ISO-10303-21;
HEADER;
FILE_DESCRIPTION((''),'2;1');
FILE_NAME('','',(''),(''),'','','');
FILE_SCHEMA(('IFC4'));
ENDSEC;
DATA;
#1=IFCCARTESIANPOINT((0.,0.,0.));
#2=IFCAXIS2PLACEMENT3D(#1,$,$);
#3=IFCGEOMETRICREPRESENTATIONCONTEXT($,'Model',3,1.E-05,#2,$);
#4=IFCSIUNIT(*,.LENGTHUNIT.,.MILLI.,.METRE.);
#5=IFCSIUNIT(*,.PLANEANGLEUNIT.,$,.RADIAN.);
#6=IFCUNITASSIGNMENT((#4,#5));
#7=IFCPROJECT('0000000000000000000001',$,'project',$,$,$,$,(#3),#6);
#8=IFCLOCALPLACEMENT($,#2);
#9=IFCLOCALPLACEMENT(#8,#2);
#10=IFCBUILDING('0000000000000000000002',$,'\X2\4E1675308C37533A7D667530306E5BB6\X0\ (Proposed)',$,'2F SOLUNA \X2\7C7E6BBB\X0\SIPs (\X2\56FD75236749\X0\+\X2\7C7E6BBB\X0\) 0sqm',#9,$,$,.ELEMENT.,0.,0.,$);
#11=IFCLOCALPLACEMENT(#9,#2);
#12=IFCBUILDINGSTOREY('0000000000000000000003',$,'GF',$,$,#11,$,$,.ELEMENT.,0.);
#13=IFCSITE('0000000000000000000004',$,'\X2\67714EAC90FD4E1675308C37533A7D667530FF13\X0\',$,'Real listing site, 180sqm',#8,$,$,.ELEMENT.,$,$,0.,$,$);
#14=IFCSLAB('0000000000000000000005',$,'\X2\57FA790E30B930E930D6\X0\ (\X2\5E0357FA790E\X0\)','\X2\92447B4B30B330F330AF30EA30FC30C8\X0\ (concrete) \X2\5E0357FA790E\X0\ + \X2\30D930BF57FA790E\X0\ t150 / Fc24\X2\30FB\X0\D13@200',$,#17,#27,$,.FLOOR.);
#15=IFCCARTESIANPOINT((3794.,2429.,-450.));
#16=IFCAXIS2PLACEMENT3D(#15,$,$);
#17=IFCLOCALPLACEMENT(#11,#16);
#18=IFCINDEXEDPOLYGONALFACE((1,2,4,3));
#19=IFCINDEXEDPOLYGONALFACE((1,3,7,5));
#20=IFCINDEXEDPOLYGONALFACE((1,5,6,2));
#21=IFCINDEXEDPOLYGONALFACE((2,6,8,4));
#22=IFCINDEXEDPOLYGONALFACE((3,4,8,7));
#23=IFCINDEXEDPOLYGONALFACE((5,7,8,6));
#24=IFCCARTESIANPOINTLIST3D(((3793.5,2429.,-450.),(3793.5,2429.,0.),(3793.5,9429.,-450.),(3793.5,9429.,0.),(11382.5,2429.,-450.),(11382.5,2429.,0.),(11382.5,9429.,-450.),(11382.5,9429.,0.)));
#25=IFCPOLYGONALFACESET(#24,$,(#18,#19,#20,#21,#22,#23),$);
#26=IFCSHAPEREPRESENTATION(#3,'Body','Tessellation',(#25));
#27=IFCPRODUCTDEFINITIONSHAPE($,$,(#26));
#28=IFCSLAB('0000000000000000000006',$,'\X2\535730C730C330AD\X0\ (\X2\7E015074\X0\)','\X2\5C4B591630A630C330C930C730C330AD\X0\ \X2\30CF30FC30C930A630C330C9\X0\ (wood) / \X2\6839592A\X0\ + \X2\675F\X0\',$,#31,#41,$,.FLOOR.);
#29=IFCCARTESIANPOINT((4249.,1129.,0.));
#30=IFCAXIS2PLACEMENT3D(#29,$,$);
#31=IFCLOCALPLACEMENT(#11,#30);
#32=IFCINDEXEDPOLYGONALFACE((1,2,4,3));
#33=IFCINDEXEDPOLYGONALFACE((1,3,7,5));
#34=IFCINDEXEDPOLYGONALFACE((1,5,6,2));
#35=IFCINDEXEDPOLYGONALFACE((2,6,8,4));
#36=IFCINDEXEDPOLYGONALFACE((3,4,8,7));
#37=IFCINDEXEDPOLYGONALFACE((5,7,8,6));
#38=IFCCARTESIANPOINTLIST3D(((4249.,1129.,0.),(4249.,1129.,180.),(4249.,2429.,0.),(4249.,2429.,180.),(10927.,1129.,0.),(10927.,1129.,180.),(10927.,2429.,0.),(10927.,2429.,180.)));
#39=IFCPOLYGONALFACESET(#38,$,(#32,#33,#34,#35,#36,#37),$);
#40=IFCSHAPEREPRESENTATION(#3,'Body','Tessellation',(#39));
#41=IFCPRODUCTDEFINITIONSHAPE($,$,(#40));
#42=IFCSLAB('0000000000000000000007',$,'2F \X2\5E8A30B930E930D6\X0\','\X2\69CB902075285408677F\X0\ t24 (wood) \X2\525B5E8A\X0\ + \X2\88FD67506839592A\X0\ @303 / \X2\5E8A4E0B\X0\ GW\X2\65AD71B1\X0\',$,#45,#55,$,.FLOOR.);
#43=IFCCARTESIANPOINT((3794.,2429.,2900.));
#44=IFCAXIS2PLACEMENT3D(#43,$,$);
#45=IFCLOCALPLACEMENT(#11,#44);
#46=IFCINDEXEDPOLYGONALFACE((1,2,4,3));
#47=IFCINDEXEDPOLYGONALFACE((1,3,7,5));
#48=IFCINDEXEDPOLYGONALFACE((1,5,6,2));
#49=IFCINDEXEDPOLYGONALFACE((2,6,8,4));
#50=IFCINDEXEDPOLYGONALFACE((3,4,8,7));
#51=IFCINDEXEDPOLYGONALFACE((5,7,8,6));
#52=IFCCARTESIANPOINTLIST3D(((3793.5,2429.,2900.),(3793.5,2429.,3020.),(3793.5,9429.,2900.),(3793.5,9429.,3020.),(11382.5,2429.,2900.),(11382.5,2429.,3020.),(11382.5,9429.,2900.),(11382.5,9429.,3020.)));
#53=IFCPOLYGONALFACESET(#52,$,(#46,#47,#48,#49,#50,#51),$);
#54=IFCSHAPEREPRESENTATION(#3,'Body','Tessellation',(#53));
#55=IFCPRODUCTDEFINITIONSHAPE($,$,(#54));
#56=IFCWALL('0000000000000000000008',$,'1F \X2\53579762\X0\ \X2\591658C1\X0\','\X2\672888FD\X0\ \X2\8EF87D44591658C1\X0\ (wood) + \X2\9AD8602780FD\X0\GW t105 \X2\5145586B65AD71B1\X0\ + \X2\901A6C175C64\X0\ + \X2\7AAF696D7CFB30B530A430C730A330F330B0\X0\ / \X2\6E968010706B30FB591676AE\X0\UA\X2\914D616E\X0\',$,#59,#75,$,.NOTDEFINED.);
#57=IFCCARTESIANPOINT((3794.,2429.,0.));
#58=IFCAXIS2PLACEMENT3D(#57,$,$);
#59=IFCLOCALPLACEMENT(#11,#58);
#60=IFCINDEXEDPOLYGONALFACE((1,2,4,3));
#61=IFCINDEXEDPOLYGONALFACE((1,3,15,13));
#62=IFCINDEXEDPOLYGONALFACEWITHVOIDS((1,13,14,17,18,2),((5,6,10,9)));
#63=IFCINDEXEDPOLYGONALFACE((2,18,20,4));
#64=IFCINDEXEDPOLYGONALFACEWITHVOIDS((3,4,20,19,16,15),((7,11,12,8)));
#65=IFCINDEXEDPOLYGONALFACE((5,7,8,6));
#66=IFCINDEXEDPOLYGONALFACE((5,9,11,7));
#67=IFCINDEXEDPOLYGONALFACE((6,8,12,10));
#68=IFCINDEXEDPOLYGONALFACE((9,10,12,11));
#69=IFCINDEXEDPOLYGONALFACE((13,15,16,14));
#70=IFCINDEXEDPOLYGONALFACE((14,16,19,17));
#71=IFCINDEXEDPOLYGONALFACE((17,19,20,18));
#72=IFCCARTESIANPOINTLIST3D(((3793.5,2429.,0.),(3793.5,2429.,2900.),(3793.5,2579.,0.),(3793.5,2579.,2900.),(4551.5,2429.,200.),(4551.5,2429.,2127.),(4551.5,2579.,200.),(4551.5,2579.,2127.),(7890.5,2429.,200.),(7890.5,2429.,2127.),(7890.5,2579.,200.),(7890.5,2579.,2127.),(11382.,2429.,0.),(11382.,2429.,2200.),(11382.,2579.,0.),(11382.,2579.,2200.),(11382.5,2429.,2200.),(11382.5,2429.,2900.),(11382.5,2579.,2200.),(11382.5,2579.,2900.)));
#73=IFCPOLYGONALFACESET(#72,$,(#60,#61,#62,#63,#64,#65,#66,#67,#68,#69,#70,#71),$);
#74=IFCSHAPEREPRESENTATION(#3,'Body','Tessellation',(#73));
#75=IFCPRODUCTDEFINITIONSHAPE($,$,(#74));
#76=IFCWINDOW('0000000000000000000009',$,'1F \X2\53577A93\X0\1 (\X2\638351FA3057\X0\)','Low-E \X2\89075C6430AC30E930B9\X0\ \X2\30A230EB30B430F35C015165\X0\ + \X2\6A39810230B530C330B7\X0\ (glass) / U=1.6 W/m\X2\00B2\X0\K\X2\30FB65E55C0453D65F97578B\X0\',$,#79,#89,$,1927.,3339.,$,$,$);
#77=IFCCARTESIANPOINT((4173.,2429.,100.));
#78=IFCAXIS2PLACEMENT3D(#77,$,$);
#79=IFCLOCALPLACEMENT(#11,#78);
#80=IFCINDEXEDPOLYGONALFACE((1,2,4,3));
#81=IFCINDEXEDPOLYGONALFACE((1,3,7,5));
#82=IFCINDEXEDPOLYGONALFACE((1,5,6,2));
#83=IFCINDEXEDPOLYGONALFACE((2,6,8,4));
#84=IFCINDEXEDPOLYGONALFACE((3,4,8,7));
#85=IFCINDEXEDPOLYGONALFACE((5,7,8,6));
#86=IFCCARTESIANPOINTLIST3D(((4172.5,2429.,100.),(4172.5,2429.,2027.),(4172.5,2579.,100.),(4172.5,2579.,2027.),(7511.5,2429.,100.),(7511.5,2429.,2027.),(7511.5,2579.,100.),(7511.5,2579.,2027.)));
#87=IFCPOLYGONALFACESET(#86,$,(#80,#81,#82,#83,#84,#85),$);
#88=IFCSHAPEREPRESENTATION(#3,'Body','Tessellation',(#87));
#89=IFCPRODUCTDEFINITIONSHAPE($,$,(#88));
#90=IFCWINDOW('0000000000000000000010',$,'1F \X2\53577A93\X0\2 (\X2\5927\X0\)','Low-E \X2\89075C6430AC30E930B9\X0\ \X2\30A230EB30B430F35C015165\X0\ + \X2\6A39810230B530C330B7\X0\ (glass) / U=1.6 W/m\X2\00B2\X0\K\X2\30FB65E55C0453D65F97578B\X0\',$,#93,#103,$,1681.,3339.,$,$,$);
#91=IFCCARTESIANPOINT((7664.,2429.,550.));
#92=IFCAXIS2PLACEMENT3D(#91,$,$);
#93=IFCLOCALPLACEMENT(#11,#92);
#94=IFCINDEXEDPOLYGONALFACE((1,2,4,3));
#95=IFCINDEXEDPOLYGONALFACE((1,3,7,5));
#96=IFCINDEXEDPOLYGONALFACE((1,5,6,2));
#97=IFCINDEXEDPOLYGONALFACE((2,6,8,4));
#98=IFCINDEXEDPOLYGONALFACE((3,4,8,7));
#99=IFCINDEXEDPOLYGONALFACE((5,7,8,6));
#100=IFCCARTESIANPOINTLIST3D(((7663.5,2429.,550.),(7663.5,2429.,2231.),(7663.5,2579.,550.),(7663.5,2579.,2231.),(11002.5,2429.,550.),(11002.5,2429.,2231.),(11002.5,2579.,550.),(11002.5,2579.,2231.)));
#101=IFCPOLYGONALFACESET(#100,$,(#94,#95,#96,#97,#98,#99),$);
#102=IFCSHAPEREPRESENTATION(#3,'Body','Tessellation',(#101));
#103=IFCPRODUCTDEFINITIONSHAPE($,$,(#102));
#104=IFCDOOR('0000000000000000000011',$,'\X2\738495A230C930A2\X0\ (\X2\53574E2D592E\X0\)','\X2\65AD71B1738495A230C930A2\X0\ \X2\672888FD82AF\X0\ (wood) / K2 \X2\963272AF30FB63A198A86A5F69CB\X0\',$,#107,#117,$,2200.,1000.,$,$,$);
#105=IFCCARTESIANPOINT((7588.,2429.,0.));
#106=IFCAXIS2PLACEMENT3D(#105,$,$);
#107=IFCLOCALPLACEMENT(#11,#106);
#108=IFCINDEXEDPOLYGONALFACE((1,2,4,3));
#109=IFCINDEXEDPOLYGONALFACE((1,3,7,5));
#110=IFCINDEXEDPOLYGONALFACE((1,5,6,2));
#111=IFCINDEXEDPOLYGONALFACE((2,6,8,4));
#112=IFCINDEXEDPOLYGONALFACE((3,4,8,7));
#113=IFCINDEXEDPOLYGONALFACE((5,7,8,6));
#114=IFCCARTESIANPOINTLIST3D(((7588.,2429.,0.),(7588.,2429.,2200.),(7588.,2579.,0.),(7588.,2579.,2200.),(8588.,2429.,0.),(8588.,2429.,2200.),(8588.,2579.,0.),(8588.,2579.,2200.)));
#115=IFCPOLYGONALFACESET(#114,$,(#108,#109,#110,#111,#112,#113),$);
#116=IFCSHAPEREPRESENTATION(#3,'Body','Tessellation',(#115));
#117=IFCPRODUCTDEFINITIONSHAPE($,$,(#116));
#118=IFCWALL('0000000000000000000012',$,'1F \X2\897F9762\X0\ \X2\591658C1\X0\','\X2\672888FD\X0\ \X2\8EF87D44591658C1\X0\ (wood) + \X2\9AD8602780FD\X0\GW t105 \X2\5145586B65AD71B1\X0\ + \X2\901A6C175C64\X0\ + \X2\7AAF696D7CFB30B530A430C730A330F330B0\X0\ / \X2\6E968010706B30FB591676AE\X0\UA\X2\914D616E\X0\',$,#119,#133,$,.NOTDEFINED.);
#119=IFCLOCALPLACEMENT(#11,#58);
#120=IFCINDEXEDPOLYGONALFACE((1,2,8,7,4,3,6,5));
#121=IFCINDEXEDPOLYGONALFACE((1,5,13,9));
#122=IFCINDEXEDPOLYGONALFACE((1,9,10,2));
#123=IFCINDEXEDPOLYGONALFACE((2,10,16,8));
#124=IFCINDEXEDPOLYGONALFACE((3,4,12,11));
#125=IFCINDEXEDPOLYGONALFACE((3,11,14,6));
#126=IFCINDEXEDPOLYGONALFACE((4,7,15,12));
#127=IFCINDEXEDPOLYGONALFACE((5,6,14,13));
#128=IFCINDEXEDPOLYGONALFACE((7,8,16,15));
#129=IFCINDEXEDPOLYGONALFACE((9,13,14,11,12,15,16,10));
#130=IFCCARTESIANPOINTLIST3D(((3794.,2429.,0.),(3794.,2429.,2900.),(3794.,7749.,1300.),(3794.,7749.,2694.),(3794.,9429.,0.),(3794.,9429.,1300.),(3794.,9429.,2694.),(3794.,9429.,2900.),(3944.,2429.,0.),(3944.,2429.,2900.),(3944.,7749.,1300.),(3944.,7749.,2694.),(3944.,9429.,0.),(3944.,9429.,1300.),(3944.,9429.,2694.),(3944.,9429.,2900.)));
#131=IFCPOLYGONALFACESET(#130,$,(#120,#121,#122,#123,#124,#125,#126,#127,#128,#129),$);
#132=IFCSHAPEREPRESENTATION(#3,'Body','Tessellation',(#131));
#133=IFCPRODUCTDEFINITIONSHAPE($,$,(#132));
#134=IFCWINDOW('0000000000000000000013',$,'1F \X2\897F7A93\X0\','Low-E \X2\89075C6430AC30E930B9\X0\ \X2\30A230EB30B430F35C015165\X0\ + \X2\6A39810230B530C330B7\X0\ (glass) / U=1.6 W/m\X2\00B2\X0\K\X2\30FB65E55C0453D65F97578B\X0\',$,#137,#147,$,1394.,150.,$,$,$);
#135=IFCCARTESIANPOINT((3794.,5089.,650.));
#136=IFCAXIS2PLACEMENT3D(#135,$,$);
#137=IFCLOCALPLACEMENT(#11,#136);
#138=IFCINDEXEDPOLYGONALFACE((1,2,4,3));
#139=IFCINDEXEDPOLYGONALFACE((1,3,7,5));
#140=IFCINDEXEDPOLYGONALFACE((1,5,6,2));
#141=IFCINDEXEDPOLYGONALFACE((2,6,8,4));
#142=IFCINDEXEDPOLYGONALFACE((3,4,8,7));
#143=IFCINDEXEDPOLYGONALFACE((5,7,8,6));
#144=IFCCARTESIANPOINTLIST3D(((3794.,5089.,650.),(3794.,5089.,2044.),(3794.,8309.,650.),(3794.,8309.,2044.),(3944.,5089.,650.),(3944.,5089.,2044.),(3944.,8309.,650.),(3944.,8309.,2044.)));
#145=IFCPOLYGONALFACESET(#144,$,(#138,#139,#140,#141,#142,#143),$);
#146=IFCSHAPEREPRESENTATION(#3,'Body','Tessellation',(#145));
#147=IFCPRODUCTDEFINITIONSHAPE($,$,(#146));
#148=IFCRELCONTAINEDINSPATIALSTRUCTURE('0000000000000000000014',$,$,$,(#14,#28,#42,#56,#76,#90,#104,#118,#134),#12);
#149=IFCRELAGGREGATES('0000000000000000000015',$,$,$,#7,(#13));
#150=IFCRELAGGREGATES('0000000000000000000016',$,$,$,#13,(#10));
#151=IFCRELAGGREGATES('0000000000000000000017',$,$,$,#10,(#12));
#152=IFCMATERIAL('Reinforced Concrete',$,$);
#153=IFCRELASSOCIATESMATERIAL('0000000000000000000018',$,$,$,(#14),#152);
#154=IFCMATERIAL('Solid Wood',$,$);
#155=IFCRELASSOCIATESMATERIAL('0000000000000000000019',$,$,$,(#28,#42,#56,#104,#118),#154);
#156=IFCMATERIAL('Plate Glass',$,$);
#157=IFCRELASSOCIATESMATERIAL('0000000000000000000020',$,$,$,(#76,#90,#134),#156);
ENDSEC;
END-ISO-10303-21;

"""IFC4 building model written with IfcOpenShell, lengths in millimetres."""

from ifc_helpers import new_model, si_unit, frame, frame_2d, origin, place, context, project, spatial, rectangle, extrude, material, element, fill, save


model = new_model("IFC4")

# Units and contexts
model_context = context("Model", 3, precision=1e-05, world=origin())
ifc_project = project(units=[si_unit("LENGTHUNIT", "METRE", prefix="MILLI"), si_unit("PLANEANGLEUNIT", "RADIAN")], contexts=[model_context])

# Site, building, storey
site_placement = place(None, origin())
site = spatial("IfcSite", under=ifc_project, at=site_placement, Name="東京都世田谷区給田３", ObjectType="Real listing site, 180sqm", CompositionType="ELEMENT", RefElevation=0.0)
building_placement = place(site_placement, origin())
building = spatial("IfcBuilding", under=site, at=building_placement, Name="世田谷区給田の家 (Proposed)", ObjectType="2F SOLUNA 籾殻SIPs (国産杉+籾殻) 0sqm", CompositionType="ELEMENT", ElevationOfRefHeight=0.0, ElevationOfTerrain=0.0)
storey_placement = place(building_placement, origin())
storey = spatial("IfcBuildingStorey", under=building, at=storey_placement, Name="GF", CompositionType="ELEMENT", Elevation=0.0)

# Slabs
ifc_material_1 = material(Name="Reinforced Concrete")
slab_1_placement = place(storey_placement, frame((3794.0, 2429.0, -450.0)))
element("IfcSlab", 1, at=slab_1_placement, inside=storey, material=ifc_material_1, Name="基礎スラブ (布基礎)", Description="鉄筋コンクリート (concrete) 布基礎 + ベタ基礎 t150 / Fc24・D13@200", PredefinedType="FLOOR", context=model_context, shape_type="SweptSolid", body=[
    extrude(rectangle(XDim=7589.0, YDim=7000.0, at=frame_2d((3794.0, 3500.0))), frame((3794.0, 2429.0, -450.0)), (0.0, 0.0, 1.0), 450.0),
])
ifc_material_2 = material(Name="Solid Wood")
slab_2_placement = place(storey_placement, frame((4249.0, 1129.0, 0.0)))
element("IfcSlab", 2, at=slab_2_placement, inside=storey, material=ifc_material_2, Name="南デッキ (縁側)", Description="屋外ウッドデッキ ハードウッド (wood) / 根太 + 束", PredefinedType="FLOOR", context=model_context, shape_type="SweptSolid", body=[
    extrude(rectangle(XDim=6678.0, YDim=1300.0, at=frame_2d((3339.0, 650.0))), frame((4249.0, 1129.0, 0.0)), (0.0, 0.0, 1.0), 180.0),
])
slab_3_placement = place(storey_placement, frame((3794.0, 2429.0, 2900.0)))
element("IfcSlab", 3, at=slab_3_placement, inside=storey, material=ifc_material_2, Name="2F 床スラブ", Description="構造用合板 t24 (wood) 剛床 + 製材根太 @303 / 床下 GW断熱", PredefinedType="FLOOR", context=model_context, shape_type="SweptSolid", body=[
    extrude(rectangle(XDim=7589.0, YDim=7000.0, at=frame_2d((3794.0, 3500.0))), frame((3794.0, 2429.0, 2900.0)), (0.0, 0.0, 1.0), 120.0),
])

# Wall, openings, windows, door
wall_1_placement = place(storey_placement, frame((3794.0, 2429.0, 0.0)))
wall_1 = element("IfcWall", 4, at=wall_1_placement, inside=storey, material=ifc_material_2, Name="1F 南面 外壁", Description="木製 軸組外壁 (wood) + 高性能GW t105 充填断熱 + 通気層 + 窯業系サイディング / 準耐火・外皮UA配慮", PredefinedType="NOTDEFINED", context=model_context, shape_type="SweptSolid", body=[
    extrude(rectangle(XDim=7589.0, YDim=150.0, at=frame_2d((3794.0, 75.0))), frame((3794.0, 2429.0, 0.0)), (0.0, 0.0, 1.0), 2900.0),
])
opening_1_placement = place(storey_placement, frame((4173.0, 2429.0, 100.0)))
opening_1 = element("IfcOpeningElement", 5, at=opening_1_placement, cuts=wall_1, PredefinedType="NOTDEFINED", context=model_context, shape_type="SweptSolid", body=[
    extrude(rectangle(XDim=3339.0, YDim=150.0, at=frame_2d((1669.0, 75.0))), frame((4173.0, 2429.0, 100.0)), (0.0, 0.0, 1.0), 1927.0),
])
opening_2_placement = place(storey_placement, frame((7664.0, 2429.0, 550.0)))
opening_2 = element("IfcOpeningElement", 6, at=opening_2_placement, cuts=wall_1, PredefinedType="NOTDEFINED", context=model_context, shape_type="SweptSolid", body=[
    extrude(rectangle(XDim=3339.0, YDim=150.0, at=frame_2d((1669.0, 75.0))), frame((7664.0, 2429.0, 550.0)), (0.0, 0.0, 1.0), 1681.0),
])
opening_3_placement = place(storey_placement, frame((7588.0, 2429.0, 0.0)))
opening_3 = element("IfcOpeningElement", 7, at=opening_3_placement, cuts=wall_1, PredefinedType="NOTDEFINED", context=model_context, shape_type="SweptSolid", body=[
    extrude(rectangle(XDim=1000.0, YDim=150.0, at=frame_2d((500.0, 75.0))), frame((7588.0, 2429.0, 0.0)), (0.0, 0.0, 1.0), 2200.0),
])
ifc_material_3 = material(Name="Plate Glass")
window_1_placement = place(storey_placement, frame((4173.0, 2429.0, 100.0)))
window_1 = element("IfcWindow", 8, at=window_1_placement, inside=storey, material=ifc_material_3, Name="1F 南窓1 (掃出し)", Description="Low-E 複層ガラス アルゴン封入 + 樹脂サッシ (glass) / U=1.6 W/m²K・日射取得型", OverallHeight=1927.0, OverallWidth=3339.0, context=model_context, shape_type="SweptSolid", body=[
    extrude(rectangle(XDim=3339.0, YDim=150.0, at=frame_2d((1669.0, 75.0))), frame((4173.0, 2429.0, 100.0)), (0.0, 0.0, 1.0), 1927.0),
])
fill(opening_1, window_1)
window_2_placement = place(storey_placement, frame((7664.0, 2429.0, 550.0)))
window_2 = element("IfcWindow", 9, at=window_2_placement, inside=storey, material=ifc_material_3, Name="1F 南窓2 (大)", Description="Low-E 複層ガラス アルゴン封入 + 樹脂サッシ (glass) / U=1.6 W/m²K・日射取得型", OverallHeight=1681.0, OverallWidth=3339.0, context=model_context, shape_type="SweptSolid", body=[
    extrude(rectangle(XDim=3339.0, YDim=150.0, at=frame_2d((1669.0, 75.0))), frame((7664.0, 2429.0, 550.0)), (0.0, 0.0, 1.0), 1681.0),
])
fill(opening_2, window_2)
door_placement = place(storey_placement, frame((7588.0, 2429.0, 0.0)))
door = element("IfcDoor", 10, at=door_placement, inside=storey, material=ifc_material_2, Name="玄関ドア (南中央)", Description="断熱玄関ドア 木製芯 (wood) / K2 防犯・採風機構", OverallHeight=2200.0, OverallWidth=1000.0, context=model_context, shape_type="SweptSolid", body=[
    extrude(rectangle(XDim=1000.0, YDim=150.0, at=frame_2d((500.0, 75.0))), frame((7588.0, 2429.0, 0.0)), (0.0, 0.0, 1.0), 2200.0),
])
fill(opening_3, door)

# Wall, opening, window
wall_2_placement = place(storey_placement, frame((3794.0, 2429.0, 0.0)))
wall_2 = element("IfcWall", 11, at=wall_2_placement, inside=storey, material=ifc_material_2, Name="1F 西面 外壁", Description="木製 軸組外壁 (wood) + 高性能GW t105 充填断熱 + 通気層 + 窯業系サイディング / 準耐火・外皮UA配慮", PredefinedType="NOTDEFINED", context=model_context, shape_type="SweptSolid", body=[
    extrude(rectangle(XDim=150.0, YDim=7000.0, at=frame_2d((75.0, 3500.0))), frame((3794.0, 2429.0, 0.0)), (0.0, 0.0, 1.0), 2900.0),
])
opening_4_placement = place(storey_placement, frame((3794.0, 5089.0, 650.0)))
opening_4 = element("IfcOpeningElement", 12, at=opening_4_placement, cuts=wall_2, PredefinedType="NOTDEFINED", context=model_context, shape_type="SweptSolid", body=[
    extrude(rectangle(XDim=150.0, YDim=3220.0, at=frame_2d((75.0, 1610.0))), frame((3794.0, 5089.0, 650.0)), (0.0, 0.0, 1.0), 1394.0),
])
window_3_placement = place(storey_placement, frame((3794.0, 5089.0, 650.0)))
window_3 = element("IfcWindow", 13, at=window_3_placement, inside=storey, material=ifc_material_3, Name="1F 西窓", Description="Low-E 複層ガラス アルゴン封入 + 樹脂サッシ (glass) / U=1.6 W/m²K・日射取得型", OverallHeight=1394.0, OverallWidth=150.0, context=model_context, shape_type="SweptSolid", body=[
    extrude(rectangle(XDim=150.0, YDim=3220.0, at=frame_2d((75.0, 1610.0))), frame((3794.0, 5089.0, 650.0)), (0.0, 0.0, 1.0), 1394.0),
])
fill(opening_4, window_3)

save(model, "model.ifc")
